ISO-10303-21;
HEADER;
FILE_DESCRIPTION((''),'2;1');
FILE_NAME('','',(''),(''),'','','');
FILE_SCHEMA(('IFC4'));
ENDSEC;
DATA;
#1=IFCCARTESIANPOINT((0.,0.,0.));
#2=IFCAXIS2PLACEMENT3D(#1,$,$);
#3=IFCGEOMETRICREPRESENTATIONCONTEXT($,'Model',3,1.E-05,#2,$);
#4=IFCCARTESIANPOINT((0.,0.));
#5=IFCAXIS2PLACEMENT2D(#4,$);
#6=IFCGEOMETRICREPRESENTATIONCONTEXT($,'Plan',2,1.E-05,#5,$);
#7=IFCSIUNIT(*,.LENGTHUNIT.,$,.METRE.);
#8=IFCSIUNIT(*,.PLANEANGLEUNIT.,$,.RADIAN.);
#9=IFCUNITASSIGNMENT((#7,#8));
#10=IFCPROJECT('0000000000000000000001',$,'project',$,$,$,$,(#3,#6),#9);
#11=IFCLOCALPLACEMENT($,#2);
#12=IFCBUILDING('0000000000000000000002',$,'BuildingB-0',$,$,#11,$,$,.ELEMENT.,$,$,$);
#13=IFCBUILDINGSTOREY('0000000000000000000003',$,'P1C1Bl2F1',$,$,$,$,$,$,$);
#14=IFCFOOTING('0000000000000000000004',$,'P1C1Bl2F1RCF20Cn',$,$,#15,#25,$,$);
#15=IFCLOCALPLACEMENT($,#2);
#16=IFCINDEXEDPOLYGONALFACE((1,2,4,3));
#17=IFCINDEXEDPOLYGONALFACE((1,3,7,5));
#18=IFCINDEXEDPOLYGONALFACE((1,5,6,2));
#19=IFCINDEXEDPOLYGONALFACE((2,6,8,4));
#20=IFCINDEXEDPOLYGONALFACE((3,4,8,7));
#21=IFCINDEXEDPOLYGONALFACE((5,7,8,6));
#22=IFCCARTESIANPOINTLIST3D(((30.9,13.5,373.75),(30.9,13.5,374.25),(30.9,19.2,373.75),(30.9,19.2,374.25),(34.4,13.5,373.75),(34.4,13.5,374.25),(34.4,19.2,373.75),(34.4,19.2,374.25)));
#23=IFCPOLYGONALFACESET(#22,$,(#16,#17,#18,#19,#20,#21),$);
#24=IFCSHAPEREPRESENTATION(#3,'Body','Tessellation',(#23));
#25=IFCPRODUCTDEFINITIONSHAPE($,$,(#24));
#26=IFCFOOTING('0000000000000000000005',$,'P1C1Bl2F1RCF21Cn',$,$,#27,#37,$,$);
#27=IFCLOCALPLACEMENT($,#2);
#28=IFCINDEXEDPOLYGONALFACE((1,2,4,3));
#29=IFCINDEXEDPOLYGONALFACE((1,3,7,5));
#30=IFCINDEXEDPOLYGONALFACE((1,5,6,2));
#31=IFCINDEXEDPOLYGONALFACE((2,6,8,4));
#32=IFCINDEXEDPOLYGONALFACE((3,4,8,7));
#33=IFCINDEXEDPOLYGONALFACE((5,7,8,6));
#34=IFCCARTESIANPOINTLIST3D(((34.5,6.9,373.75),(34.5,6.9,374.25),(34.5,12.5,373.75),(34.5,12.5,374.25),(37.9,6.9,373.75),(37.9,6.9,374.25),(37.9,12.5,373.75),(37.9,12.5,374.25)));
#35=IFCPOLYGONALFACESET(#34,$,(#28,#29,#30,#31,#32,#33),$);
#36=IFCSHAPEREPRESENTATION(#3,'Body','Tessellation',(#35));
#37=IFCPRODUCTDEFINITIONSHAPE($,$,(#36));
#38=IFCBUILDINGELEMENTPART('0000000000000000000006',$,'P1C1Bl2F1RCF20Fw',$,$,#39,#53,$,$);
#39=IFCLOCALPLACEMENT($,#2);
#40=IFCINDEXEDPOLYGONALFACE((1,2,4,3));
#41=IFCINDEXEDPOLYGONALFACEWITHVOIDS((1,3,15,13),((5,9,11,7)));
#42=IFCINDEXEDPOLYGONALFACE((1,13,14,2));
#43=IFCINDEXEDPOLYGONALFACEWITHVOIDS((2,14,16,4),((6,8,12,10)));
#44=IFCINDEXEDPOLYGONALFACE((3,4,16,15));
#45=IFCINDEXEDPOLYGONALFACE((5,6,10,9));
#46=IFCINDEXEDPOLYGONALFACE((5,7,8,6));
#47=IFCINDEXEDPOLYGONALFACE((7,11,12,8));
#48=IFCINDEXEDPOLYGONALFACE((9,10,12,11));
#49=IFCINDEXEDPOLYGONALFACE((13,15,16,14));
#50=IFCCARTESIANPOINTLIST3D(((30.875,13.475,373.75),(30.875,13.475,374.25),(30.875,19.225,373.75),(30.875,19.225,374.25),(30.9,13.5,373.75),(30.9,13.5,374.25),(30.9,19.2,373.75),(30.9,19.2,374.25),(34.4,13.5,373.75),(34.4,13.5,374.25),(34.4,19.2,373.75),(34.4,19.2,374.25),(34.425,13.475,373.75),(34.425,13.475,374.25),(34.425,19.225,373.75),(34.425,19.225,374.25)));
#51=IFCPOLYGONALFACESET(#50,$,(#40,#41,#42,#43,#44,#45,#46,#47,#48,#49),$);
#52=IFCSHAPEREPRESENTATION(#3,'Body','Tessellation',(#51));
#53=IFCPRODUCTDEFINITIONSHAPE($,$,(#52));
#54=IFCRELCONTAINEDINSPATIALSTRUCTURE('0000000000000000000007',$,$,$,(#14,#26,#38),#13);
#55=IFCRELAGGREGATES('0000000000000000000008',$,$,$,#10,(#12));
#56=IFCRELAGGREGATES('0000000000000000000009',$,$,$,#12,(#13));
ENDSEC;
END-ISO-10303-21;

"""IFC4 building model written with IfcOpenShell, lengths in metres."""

from ifc_helpers import new_model, si_unit, origin, origin_2d, place, context, project, spatial, polyline, outline, extrude, element, save


model = new_model("IFC4")

# Units and contexts
model_context = context("Model", 3, precision=1e-05, world=origin())
plan_context = context("Plan", 2, precision=1e-05, world=origin_2d())
ifc_project = project(units=[si_unit("LENGTHUNIT", "METRE"), si_unit("PLANEANGLEUNIT", "RADIAN")], contexts=[model_context, plan_context])

# Building, storey
building_placement = place(None, origin())
building = spatial("IfcBuilding", under=ifc_project, at=building_placement, Name="BuildingB-0", CompositionType="ELEMENT")
storey = spatial("IfcBuildingStorey", under=building, Name="P1C1Bl2F1")

# Footings
element("IfcFooting", 1, inside=storey, Name="P1C1Bl2F1RCF20Cn", context=model_context, shape_type="SweptSolid", body=[
    extrude(outline(polyline([(34.4, 19.2, 373.75), (30.9, 19.2, 373.75), (30.9, 13.5, 373.75), (34.4, 13.5, 373.75), (34.4, 19.2, 373.75)])), None, (0.0, 0.0, 1.0), 0.5),
])
element("IfcFooting", 2, inside=storey, Name="P1C1Bl2F1RCF21Cn", context=model_context, shape_type="SweptSolid", body=[
    extrude(outline(polyline([(37.9, 12.5, 373.75), (34.5, 12.5, 373.75), (34.5, 6.9, 373.75), (37.9, 6.9, 373.75), (37.9, 12.5, 373.75)])), None, (0.0, 0.0, 1.0), 0.5),
])

# Building element part, opening
building_element_part = element("IfcBuildingElementPart", 3, inside=storey, Name="P1C1Bl2F1RCF20Fw", context=model_context, shape_type="SweptSolid", body=[
    extrude(outline(polyline([(34.425, 19.225, 373.75), (30.875, 19.225, 373.75), (30.875, 13.475, 373.75), (34.425, 13.475, 373.75), (34.425, 19.225, 373.75)])), None, (0.0, 0.0, 1.0), 0.5),
])
element("IfcOpeningElement", 4, inside=storey, cuts=building_element_part, context=model_context, shape_type="SweptSolid", body=[
    extrude(outline(polyline([(34.4, 19.2, 373.75), (30.9, 19.2, 373.75), (30.9, 13.5, 373.75), (34.4, 13.5, 373.75), (34.4, 19.2, 373.75)])), None, (0.0, 0.0, 1.0), 0.5),
])

save(model, "model.ifc")
